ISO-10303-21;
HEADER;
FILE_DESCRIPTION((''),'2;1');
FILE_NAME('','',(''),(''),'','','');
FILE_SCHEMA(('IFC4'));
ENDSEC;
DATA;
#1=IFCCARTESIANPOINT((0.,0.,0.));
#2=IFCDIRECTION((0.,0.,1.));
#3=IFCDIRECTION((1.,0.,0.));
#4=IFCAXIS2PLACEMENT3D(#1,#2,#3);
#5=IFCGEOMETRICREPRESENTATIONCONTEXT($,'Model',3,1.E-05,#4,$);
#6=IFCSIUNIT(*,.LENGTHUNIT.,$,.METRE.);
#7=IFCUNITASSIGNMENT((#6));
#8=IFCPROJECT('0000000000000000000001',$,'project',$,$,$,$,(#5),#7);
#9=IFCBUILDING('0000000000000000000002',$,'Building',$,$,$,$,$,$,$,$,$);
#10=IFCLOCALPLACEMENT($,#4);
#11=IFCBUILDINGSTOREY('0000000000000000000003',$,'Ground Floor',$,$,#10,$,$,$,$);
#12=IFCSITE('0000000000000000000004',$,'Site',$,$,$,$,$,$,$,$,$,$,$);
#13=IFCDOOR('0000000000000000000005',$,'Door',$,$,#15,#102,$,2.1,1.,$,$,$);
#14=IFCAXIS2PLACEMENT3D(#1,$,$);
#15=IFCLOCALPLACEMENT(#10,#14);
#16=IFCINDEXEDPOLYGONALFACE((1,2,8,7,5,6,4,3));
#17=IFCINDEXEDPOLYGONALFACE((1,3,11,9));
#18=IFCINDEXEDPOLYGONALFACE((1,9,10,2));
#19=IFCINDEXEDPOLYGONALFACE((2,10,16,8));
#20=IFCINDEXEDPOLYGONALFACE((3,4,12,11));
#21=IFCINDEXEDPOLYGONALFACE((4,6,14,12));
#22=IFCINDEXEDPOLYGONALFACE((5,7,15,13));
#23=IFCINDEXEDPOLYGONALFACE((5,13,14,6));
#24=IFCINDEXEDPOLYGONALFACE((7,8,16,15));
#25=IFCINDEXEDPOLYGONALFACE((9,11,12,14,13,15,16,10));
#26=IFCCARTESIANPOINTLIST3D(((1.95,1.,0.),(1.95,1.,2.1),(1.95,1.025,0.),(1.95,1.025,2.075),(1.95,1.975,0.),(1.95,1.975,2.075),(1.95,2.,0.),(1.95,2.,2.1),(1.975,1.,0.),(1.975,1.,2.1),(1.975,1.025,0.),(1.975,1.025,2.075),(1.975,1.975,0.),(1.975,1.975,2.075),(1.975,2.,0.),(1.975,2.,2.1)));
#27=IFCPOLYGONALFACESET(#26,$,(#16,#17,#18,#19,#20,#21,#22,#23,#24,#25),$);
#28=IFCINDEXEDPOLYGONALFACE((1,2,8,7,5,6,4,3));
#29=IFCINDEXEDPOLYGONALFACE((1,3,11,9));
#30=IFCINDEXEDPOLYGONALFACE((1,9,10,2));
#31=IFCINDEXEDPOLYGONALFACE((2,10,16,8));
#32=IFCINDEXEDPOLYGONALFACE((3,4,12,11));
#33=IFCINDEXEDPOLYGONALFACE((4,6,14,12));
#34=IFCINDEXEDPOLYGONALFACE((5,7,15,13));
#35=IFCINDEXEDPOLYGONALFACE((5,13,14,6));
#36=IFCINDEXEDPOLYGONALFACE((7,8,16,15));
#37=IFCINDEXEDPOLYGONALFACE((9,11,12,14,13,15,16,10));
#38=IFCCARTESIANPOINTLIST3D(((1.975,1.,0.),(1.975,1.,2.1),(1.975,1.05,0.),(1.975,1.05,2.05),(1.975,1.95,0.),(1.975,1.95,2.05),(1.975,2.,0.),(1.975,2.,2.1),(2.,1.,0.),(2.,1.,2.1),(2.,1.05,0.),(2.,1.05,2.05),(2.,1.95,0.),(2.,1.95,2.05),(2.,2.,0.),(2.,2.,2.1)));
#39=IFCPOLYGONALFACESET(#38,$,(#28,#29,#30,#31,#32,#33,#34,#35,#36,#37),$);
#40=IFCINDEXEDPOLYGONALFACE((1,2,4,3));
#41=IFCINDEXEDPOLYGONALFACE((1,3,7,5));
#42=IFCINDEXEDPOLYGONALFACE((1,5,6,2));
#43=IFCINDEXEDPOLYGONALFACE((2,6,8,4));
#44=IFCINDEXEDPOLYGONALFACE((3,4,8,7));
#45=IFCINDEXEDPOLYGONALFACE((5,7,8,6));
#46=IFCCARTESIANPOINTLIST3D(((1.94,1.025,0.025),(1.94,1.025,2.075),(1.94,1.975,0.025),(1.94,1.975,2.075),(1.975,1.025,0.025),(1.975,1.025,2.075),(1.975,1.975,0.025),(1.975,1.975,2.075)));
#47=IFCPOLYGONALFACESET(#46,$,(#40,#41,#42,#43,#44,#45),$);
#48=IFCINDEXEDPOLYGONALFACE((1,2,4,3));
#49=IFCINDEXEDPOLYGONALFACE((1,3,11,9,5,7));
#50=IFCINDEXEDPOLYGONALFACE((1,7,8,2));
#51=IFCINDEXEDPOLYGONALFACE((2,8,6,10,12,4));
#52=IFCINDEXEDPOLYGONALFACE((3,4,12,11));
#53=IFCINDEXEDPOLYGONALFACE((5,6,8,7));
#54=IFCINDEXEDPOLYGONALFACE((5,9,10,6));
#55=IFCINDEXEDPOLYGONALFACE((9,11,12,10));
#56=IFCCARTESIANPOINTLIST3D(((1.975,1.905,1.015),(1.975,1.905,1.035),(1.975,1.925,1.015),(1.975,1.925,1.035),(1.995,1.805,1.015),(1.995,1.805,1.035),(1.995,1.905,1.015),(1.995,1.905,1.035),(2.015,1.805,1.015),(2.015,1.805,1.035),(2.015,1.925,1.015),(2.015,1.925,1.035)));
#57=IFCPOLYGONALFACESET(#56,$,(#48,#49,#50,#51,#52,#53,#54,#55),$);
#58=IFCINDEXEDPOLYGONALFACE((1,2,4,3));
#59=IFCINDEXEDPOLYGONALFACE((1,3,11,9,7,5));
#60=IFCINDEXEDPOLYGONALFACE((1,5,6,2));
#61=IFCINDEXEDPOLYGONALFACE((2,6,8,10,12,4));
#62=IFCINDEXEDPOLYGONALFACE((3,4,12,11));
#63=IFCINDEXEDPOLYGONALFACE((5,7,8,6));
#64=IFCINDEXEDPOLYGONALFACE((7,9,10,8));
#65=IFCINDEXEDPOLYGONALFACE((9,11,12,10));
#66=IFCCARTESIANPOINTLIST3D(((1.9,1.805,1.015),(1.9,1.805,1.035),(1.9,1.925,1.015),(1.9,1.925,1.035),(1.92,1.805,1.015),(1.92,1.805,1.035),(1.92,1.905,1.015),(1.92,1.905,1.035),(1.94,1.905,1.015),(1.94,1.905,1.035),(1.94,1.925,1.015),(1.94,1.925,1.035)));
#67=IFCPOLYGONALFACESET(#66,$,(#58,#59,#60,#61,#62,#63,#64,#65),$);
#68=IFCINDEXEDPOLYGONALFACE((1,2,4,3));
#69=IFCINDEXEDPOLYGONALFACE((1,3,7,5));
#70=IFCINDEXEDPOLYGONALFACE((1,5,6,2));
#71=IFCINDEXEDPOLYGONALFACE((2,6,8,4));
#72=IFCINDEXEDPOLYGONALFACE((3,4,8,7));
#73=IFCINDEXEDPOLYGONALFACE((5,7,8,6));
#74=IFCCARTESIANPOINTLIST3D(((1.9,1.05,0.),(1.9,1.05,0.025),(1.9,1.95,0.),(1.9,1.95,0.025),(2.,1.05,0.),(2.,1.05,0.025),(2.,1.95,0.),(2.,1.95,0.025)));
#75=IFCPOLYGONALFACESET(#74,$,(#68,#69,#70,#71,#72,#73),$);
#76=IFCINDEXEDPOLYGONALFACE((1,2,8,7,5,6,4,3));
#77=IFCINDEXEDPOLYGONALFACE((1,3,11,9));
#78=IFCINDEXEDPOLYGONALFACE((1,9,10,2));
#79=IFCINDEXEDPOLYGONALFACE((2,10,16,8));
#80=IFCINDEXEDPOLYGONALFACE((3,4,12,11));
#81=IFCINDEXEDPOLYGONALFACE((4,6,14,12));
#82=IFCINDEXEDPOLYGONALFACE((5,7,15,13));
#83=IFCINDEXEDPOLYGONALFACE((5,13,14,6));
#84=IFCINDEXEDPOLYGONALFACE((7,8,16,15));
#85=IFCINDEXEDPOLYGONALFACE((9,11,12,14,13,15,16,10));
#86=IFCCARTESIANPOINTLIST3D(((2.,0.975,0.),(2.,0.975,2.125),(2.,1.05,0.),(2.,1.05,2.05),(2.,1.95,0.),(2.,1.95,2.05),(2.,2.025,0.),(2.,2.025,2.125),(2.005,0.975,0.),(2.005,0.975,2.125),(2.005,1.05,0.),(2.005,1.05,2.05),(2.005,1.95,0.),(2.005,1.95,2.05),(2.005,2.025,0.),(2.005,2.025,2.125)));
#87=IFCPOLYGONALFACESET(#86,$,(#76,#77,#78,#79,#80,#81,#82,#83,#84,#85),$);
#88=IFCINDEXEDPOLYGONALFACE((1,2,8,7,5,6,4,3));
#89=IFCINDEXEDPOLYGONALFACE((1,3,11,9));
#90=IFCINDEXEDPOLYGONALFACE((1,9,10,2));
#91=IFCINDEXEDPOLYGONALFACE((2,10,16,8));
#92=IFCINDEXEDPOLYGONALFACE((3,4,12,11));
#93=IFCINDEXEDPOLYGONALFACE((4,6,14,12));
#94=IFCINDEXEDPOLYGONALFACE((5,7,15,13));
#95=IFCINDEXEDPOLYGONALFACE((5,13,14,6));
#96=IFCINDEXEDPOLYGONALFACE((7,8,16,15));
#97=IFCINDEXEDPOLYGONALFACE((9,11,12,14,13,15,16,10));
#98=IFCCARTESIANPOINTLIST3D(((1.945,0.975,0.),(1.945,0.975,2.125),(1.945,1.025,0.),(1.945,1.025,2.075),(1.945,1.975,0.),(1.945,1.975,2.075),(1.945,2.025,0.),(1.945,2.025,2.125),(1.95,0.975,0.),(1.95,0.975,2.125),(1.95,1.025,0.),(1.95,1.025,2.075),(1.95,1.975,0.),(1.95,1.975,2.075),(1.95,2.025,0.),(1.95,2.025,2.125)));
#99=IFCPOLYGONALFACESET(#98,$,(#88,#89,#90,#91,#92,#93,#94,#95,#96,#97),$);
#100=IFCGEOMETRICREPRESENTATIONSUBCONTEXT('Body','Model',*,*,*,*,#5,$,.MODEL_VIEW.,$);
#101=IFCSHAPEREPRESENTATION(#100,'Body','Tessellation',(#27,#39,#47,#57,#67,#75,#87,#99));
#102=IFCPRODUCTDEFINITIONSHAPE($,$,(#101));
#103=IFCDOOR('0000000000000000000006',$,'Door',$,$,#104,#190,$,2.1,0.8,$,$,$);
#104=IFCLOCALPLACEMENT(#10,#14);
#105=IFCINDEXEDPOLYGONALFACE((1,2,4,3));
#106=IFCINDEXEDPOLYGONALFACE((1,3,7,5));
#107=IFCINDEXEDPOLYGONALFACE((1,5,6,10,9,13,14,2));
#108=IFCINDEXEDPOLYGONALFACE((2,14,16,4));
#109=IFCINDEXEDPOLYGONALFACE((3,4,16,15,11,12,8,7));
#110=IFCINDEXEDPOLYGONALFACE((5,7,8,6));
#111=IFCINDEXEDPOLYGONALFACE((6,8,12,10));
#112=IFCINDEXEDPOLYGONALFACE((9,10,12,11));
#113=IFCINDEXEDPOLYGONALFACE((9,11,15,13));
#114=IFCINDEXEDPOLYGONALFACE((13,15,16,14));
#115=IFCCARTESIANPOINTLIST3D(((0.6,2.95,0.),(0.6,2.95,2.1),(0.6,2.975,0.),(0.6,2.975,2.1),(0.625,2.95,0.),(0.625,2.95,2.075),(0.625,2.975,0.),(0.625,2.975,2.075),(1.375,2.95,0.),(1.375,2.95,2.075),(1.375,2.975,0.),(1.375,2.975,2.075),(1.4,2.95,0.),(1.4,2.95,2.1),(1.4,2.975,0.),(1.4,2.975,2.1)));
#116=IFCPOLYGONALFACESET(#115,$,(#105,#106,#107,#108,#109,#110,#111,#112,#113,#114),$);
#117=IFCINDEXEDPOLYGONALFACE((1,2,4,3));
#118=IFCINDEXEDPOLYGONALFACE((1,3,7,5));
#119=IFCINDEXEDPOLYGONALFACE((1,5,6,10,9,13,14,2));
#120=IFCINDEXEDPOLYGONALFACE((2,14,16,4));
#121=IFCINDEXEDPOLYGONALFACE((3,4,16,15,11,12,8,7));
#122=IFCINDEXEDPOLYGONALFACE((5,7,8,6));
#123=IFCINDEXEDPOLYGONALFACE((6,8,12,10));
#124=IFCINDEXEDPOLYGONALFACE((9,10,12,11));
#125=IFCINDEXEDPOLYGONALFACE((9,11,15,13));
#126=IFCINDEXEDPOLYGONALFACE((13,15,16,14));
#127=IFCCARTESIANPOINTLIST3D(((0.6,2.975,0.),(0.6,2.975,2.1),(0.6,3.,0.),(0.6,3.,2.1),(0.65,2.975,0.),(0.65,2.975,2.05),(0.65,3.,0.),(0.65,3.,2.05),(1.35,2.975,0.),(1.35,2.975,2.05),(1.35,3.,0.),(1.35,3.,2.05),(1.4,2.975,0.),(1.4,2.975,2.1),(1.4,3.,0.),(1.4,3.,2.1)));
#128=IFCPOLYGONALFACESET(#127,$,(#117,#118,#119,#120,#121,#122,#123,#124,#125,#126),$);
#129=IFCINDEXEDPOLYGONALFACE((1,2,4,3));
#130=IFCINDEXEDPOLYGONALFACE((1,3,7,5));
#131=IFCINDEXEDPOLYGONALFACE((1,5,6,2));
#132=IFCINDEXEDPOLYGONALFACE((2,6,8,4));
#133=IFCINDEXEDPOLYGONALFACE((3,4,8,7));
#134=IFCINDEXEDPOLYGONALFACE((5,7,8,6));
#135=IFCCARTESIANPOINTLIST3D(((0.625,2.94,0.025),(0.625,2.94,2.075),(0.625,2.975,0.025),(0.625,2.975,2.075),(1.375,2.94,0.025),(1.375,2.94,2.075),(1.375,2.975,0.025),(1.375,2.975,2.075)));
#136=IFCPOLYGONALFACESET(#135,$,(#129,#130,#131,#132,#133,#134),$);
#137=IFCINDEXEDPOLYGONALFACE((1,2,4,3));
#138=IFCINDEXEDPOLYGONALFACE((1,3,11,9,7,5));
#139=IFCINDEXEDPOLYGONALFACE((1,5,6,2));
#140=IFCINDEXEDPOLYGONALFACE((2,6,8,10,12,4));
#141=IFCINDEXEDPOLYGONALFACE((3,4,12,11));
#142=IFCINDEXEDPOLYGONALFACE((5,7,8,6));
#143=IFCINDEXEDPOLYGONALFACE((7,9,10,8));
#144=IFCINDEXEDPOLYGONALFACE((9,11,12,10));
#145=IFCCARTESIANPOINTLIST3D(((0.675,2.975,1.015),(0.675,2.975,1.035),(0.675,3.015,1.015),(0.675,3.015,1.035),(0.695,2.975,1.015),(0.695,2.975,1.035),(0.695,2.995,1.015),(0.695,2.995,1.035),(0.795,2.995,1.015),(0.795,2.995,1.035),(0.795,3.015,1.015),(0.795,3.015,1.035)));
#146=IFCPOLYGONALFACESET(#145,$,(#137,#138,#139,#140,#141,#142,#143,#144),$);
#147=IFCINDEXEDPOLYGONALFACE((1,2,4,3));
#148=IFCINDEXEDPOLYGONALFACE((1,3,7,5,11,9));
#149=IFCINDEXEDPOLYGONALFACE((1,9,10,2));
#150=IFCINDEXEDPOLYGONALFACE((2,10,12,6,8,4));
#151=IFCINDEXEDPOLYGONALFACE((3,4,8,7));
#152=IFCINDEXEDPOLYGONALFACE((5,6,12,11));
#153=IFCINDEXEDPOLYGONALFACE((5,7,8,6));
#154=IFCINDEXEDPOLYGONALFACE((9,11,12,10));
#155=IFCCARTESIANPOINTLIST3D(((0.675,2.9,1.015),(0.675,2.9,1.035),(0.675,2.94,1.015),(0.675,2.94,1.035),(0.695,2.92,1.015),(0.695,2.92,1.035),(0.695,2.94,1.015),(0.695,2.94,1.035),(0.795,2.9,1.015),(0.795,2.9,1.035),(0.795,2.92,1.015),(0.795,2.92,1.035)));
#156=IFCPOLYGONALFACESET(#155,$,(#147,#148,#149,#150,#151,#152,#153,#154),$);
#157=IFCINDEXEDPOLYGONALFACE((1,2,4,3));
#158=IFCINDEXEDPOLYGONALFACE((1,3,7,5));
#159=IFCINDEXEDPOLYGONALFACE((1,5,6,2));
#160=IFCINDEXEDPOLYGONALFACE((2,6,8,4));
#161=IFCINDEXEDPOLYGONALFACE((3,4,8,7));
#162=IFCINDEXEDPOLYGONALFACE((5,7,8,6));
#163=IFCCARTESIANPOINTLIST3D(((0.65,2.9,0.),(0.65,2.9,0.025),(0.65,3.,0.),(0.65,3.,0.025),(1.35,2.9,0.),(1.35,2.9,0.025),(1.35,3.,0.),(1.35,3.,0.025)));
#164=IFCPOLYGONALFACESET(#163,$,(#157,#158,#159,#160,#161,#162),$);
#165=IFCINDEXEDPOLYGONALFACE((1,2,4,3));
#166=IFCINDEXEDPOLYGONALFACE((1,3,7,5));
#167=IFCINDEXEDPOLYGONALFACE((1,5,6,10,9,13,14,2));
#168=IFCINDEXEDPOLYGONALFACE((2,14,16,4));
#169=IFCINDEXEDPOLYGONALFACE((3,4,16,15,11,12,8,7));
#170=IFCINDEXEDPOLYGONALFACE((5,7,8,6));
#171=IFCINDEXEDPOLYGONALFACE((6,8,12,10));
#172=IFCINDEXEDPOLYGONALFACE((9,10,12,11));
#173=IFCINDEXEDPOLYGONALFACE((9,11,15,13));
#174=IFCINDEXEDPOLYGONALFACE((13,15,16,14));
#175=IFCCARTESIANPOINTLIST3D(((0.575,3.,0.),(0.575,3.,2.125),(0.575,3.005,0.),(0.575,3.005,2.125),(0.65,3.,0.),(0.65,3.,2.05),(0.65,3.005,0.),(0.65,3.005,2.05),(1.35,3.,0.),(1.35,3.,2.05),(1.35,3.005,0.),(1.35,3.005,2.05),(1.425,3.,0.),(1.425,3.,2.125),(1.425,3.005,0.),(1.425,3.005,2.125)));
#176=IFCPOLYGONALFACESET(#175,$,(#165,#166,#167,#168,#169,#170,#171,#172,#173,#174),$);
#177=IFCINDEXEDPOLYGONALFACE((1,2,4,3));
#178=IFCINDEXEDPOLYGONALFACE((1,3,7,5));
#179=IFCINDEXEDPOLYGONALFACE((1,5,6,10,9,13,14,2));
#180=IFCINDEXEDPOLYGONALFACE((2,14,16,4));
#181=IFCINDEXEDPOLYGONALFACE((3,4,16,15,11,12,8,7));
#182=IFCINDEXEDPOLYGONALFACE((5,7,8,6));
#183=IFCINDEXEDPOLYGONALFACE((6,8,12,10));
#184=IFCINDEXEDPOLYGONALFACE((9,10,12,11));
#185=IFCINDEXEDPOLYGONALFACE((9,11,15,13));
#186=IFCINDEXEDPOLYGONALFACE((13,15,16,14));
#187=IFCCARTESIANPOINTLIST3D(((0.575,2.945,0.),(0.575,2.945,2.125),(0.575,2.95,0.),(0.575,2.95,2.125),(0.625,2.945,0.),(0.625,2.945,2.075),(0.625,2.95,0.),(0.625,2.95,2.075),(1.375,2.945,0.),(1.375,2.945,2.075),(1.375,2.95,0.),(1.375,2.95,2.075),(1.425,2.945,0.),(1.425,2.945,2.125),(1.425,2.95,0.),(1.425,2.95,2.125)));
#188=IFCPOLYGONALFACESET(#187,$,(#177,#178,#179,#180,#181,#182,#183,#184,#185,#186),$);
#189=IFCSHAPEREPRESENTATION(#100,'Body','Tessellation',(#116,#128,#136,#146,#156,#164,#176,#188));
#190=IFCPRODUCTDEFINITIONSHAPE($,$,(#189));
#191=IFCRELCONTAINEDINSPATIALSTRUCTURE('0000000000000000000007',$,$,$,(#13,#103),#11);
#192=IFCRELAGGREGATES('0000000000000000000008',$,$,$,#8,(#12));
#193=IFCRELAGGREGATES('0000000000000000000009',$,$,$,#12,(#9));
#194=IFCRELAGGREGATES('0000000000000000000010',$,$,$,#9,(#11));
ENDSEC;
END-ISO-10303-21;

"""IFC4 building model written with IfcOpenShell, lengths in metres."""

from ifc_helpers import new_model, si_unit, frame, origin_with_axes, place, context, subcontext, project, spatial, line, indexed_curve, outline, extrude, element, save


model = new_model("IFC4")

# Units and contexts
model_context = context("Model", 3, precision=1e-05, world=origin_with_axes())
body_context = subcontext(model_context, "Body", "Model", "MODEL_VIEW")
ifc_project = project(units=[si_unit("LENGTHUNIT", "METRE")], contexts=[model_context])

# Site, building, storey
site = spatial("IfcSite", under=ifc_project, Name="Site")
building = spatial("IfcBuilding", under=site, Name="Building")
storey_placement = place(None, origin_with_axes())
storey = spatial("IfcBuildingStorey", under=building, at=storey_placement, Name="Ground Floor")

# Doors
door_1_placement = place(storey_placement, frame((2.0, 1.0, 0.0), z_axis=(0.0, 0.0, 1.0), x_axis=(0.0, 1.0, 0.0)))
element("IfcDoor", 1, at=door_1_placement, inside=storey, Name="Door", OverallHeight=2.1, OverallWidth=1.0, context=body_context, shape_type="SweptSolid", body=[
    extrude(outline(indexed_curve([(0.0, 0.0), (0.0, 2.1), (1.0, 2.1), (1.0, 0.0), (0.975, 0.0), (0.975, 2.075), (0.025, 2.075), (0.025, 0.0)], segments=[line(1, 2, 3, 4, 5, 6, 7, 8, 1)])), frame((0.0, 0.025, 0.0), z_axis=(0.0, -1.0, 0.0), x_axis=(1.0, 0.0, 0.0)), (0.0, 0.0, -1.0), 0.025),
    extrude(outline(indexed_curve([(0.0, 0.0), (0.0, 2.1), (1.0, 2.1), (1.0, 0.0), (0.95, 0.0), (0.95, 2.05), (0.05, 2.05), (0.05, 0.0)], segments=[line(1, 2, 3, 4, 5, 6, 7, 8, 1)])), frame((0.0, 0.0, 0.0), z_axis=(0.0, -1.0, 0.0), x_axis=(1.0, 0.0, 0.0)), (0.0, 0.0, -1.0), 0.025),
    extrude(outline(indexed_curve([(0.0, 0.0), (0.95, 0.0), (0.95, 0.035), (0.0, 0.035)], segments=[line(1, 2, 3, 4, 1)])), frame((0.025, 0.025, 0.025), z_axis=(0.0, 0.0, 1.0), x_axis=(1.0, 0.0, 0.0)), (0.0, 0.0, 1.0), 2.05),
    extrude(outline(indexed_curve([(0.0, 0.0), (0.0, -0.04), (-0.12, -0.04), (-0.12, -0.02), (-0.02, -0.02), (-0.02, 0.0)], segments=[line(1, 2, 3, 4, 5, 6, 1)])), frame((0.925, 0.025, 1.015), z_axis=(0.0, 0.0, 1.0), x_axis=(1.0, 0.0, 0.0)), (0.0, 0.0, 1.0), 0.02),
    extrude(outline(indexed_curve([(0.0, 0.0), (0.0, 0.04), (-0.12, 0.04), (-0.12, 0.02), (-0.02, 0.02), (-0.02, 0.0)], segments=[line(1, 2, 3, 4, 5, 6, 1)])), frame((0.925, 0.06, 1.015), z_axis=(0.0, 0.0, 1.0), x_axis=(1.0, 0.0, 0.0)), (0.0, 0.0, 1.0), 0.02),
    extrude(outline(indexed_curve([(0.0, 0.0), (0.9, 0.0), (0.9, 0.1), (0.0, 0.1)], segments=[line(1, 2, 3, 4, 1)])), frame((0.05, 0.0, 0.0), z_axis=(0.0, 0.0, 1.0), x_axis=(1.0, 0.0, 0.0)), (0.0, 0.0, 1.0), 0.025),
    extrude(outline(indexed_curve([(0.0, 0.0), (0.0, 2.125), (1.05, 2.125), (1.05, 0.0), (0.975, 0.0), (0.975, 2.05), (0.075, 2.05), (0.075, 0.0)], segments=[line(1, 2, 3, 4, 5, 6, 7, 8, 1)])), frame((-0.025, -0.005, 0.0), z_axis=(0.0, -1.0, 0.0), x_axis=(1.0, 0.0, 0.0)), (0.0, 0.0, -1.0), 0.005),
    extrude(outline(indexed_curve([(0.0, 0.0), (0.0, 2.125), (1.05, 2.125), (1.05, 0.0), (1.0, 0.0), (1.0, 2.075), (0.05, 2.075), (0.05, 0.0)], segments=[line(1, 2, 3, 4, 5, 6, 7, 8, 1)])), frame((-0.025, 0.05, 0.0), z_axis=(0.0, -1.0, 0.0), x_axis=(1.0, 0.0, 0.0)), (0.0, 0.0, -1.0), 0.005),
])
door_2_placement = place(storey_placement, frame((1.4, 3.0, 0.0), z_axis=(0.0, 0.0, 1.0), x_axis=(-1.0, 0.0, 0.0)))
element("IfcDoor", 2, at=door_2_placement, inside=storey, Name="Door", OverallHeight=2.1, OverallWidth=0.8, context=body_context, shape_type="SweptSolid", body=[
    extrude(outline(indexed_curve([(0.0, 0.0), (0.0, 2.1), (0.8, 2.1), (0.8, 0.0), (0.775, 0.0), (0.775, 2.075), (0.025, 2.075), (0.025, 0.0)], segments=[line(1, 2, 3, 4, 5, 6, 7, 8, 1)])), frame((0.0, 0.025, 0.0), z_axis=(0.0, -1.0, 0.0), x_axis=(1.0, 0.0, 0.0)), (0.0, 0.0, -1.0), 0.025),
    extrude(outline(indexed_curve([(0.0, 0.0), (0.0, 2.1), (0.8, 2.1), (0.8, 0.0), (0.75, 0.0), (0.75, 2.05), (0.05, 2.05), (0.05, 0.0)], segments=[line(1, 2, 3, 4, 5, 6, 7, 8, 1)])), frame((0.0, 0.0, 0.0), z_axis=(0.0, -1.0, 0.0), x_axis=(1.0, 0.0, 0.0)), (0.0, 0.0, -1.0), 0.025),
    extrude(outline(indexed_curve([(0.0, 0.0), (0.75, 0.0), (0.75, 0.035), (0.0, 0.035)], segments=[line(1, 2, 3, 4, 1)])), frame((0.025, 0.025, 0.025), z_axis=(0.0, 0.0, 1.0), x_axis=(1.0, 0.0, 0.0)), (0.0, 0.0, 1.0), 2.05),
    extrude(outline(indexed_curve([(0.0, 0.0), (0.0, -0.04), (-0.12, -0.04), (-0.12, -0.02), (-0.02, -0.02), (-0.02, 0.0)], segments=[line(1, 2, 3, 4, 5, 6, 1)])), frame((0.725, 0.025, 1.015), z_axis=(0.0, 0.0, 1.0), x_axis=(1.0, 0.0, 0.0)), (0.0, 0.0, 1.0), 0.02),
    extrude(outline(indexed_curve([(0.0, 0.0), (0.0, 0.04), (-0.12, 0.04), (-0.12, 0.02), (-0.02, 0.02), (-0.02, 0.0)], segments=[line(1, 2, 3, 4, 5, 6, 1)])), frame((0.725, 0.06, 1.015), z_axis=(0.0, 0.0, 1.0), x_axis=(1.0, 0.0, 0.0)), (0.0, 0.0, 1.0), 0.02),
    extrude(outline(indexed_curve([(0.0, 0.0), (0.7, 0.0), (0.7, 0.1), (0.0, 0.1)], segments=[line(1, 2, 3, 4, 1)])), frame((0.05, 0.0, 0.0), z_axis=(0.0, 0.0, 1.0), x_axis=(1.0, 0.0, 0.0)), (0.0, 0.0, 1.0), 0.025),
    extrude(outline(indexed_curve([(0.0, 0.0), (0.0, 2.125), (0.85, 2.125), (0.85, 0.0), (0.775, 0.0), (0.775, 2.05), (0.075, 2.05), (0.075, 0.0)], segments=[line(1, 2, 3, 4, 5, 6, 7, 8, 1)])), frame((-0.025, -0.005, 0.0), z_axis=(0.0, -1.0, 0.0), x_axis=(1.0, 0.0, 0.0)), (0.0, 0.0, -1.0), 0.005),
    extrude(outline(indexed_curve([(0.0, 0.0), (0.0, 2.125), (0.85, 2.125), (0.85, 0.0), (0.8, 0.0), (0.8, 2.075), (0.05, 2.075), (0.05, 0.0)], segments=[line(1, 2, 3, 4, 5, 6, 7, 8, 1)])), frame((-0.025, 0.05, 0.0), z_axis=(0.0, -1.0, 0.0), x_axis=(1.0, 0.0, 0.0)), (0.0, 0.0, -1.0), 0.005),
])

save(model, "model.ifc")
